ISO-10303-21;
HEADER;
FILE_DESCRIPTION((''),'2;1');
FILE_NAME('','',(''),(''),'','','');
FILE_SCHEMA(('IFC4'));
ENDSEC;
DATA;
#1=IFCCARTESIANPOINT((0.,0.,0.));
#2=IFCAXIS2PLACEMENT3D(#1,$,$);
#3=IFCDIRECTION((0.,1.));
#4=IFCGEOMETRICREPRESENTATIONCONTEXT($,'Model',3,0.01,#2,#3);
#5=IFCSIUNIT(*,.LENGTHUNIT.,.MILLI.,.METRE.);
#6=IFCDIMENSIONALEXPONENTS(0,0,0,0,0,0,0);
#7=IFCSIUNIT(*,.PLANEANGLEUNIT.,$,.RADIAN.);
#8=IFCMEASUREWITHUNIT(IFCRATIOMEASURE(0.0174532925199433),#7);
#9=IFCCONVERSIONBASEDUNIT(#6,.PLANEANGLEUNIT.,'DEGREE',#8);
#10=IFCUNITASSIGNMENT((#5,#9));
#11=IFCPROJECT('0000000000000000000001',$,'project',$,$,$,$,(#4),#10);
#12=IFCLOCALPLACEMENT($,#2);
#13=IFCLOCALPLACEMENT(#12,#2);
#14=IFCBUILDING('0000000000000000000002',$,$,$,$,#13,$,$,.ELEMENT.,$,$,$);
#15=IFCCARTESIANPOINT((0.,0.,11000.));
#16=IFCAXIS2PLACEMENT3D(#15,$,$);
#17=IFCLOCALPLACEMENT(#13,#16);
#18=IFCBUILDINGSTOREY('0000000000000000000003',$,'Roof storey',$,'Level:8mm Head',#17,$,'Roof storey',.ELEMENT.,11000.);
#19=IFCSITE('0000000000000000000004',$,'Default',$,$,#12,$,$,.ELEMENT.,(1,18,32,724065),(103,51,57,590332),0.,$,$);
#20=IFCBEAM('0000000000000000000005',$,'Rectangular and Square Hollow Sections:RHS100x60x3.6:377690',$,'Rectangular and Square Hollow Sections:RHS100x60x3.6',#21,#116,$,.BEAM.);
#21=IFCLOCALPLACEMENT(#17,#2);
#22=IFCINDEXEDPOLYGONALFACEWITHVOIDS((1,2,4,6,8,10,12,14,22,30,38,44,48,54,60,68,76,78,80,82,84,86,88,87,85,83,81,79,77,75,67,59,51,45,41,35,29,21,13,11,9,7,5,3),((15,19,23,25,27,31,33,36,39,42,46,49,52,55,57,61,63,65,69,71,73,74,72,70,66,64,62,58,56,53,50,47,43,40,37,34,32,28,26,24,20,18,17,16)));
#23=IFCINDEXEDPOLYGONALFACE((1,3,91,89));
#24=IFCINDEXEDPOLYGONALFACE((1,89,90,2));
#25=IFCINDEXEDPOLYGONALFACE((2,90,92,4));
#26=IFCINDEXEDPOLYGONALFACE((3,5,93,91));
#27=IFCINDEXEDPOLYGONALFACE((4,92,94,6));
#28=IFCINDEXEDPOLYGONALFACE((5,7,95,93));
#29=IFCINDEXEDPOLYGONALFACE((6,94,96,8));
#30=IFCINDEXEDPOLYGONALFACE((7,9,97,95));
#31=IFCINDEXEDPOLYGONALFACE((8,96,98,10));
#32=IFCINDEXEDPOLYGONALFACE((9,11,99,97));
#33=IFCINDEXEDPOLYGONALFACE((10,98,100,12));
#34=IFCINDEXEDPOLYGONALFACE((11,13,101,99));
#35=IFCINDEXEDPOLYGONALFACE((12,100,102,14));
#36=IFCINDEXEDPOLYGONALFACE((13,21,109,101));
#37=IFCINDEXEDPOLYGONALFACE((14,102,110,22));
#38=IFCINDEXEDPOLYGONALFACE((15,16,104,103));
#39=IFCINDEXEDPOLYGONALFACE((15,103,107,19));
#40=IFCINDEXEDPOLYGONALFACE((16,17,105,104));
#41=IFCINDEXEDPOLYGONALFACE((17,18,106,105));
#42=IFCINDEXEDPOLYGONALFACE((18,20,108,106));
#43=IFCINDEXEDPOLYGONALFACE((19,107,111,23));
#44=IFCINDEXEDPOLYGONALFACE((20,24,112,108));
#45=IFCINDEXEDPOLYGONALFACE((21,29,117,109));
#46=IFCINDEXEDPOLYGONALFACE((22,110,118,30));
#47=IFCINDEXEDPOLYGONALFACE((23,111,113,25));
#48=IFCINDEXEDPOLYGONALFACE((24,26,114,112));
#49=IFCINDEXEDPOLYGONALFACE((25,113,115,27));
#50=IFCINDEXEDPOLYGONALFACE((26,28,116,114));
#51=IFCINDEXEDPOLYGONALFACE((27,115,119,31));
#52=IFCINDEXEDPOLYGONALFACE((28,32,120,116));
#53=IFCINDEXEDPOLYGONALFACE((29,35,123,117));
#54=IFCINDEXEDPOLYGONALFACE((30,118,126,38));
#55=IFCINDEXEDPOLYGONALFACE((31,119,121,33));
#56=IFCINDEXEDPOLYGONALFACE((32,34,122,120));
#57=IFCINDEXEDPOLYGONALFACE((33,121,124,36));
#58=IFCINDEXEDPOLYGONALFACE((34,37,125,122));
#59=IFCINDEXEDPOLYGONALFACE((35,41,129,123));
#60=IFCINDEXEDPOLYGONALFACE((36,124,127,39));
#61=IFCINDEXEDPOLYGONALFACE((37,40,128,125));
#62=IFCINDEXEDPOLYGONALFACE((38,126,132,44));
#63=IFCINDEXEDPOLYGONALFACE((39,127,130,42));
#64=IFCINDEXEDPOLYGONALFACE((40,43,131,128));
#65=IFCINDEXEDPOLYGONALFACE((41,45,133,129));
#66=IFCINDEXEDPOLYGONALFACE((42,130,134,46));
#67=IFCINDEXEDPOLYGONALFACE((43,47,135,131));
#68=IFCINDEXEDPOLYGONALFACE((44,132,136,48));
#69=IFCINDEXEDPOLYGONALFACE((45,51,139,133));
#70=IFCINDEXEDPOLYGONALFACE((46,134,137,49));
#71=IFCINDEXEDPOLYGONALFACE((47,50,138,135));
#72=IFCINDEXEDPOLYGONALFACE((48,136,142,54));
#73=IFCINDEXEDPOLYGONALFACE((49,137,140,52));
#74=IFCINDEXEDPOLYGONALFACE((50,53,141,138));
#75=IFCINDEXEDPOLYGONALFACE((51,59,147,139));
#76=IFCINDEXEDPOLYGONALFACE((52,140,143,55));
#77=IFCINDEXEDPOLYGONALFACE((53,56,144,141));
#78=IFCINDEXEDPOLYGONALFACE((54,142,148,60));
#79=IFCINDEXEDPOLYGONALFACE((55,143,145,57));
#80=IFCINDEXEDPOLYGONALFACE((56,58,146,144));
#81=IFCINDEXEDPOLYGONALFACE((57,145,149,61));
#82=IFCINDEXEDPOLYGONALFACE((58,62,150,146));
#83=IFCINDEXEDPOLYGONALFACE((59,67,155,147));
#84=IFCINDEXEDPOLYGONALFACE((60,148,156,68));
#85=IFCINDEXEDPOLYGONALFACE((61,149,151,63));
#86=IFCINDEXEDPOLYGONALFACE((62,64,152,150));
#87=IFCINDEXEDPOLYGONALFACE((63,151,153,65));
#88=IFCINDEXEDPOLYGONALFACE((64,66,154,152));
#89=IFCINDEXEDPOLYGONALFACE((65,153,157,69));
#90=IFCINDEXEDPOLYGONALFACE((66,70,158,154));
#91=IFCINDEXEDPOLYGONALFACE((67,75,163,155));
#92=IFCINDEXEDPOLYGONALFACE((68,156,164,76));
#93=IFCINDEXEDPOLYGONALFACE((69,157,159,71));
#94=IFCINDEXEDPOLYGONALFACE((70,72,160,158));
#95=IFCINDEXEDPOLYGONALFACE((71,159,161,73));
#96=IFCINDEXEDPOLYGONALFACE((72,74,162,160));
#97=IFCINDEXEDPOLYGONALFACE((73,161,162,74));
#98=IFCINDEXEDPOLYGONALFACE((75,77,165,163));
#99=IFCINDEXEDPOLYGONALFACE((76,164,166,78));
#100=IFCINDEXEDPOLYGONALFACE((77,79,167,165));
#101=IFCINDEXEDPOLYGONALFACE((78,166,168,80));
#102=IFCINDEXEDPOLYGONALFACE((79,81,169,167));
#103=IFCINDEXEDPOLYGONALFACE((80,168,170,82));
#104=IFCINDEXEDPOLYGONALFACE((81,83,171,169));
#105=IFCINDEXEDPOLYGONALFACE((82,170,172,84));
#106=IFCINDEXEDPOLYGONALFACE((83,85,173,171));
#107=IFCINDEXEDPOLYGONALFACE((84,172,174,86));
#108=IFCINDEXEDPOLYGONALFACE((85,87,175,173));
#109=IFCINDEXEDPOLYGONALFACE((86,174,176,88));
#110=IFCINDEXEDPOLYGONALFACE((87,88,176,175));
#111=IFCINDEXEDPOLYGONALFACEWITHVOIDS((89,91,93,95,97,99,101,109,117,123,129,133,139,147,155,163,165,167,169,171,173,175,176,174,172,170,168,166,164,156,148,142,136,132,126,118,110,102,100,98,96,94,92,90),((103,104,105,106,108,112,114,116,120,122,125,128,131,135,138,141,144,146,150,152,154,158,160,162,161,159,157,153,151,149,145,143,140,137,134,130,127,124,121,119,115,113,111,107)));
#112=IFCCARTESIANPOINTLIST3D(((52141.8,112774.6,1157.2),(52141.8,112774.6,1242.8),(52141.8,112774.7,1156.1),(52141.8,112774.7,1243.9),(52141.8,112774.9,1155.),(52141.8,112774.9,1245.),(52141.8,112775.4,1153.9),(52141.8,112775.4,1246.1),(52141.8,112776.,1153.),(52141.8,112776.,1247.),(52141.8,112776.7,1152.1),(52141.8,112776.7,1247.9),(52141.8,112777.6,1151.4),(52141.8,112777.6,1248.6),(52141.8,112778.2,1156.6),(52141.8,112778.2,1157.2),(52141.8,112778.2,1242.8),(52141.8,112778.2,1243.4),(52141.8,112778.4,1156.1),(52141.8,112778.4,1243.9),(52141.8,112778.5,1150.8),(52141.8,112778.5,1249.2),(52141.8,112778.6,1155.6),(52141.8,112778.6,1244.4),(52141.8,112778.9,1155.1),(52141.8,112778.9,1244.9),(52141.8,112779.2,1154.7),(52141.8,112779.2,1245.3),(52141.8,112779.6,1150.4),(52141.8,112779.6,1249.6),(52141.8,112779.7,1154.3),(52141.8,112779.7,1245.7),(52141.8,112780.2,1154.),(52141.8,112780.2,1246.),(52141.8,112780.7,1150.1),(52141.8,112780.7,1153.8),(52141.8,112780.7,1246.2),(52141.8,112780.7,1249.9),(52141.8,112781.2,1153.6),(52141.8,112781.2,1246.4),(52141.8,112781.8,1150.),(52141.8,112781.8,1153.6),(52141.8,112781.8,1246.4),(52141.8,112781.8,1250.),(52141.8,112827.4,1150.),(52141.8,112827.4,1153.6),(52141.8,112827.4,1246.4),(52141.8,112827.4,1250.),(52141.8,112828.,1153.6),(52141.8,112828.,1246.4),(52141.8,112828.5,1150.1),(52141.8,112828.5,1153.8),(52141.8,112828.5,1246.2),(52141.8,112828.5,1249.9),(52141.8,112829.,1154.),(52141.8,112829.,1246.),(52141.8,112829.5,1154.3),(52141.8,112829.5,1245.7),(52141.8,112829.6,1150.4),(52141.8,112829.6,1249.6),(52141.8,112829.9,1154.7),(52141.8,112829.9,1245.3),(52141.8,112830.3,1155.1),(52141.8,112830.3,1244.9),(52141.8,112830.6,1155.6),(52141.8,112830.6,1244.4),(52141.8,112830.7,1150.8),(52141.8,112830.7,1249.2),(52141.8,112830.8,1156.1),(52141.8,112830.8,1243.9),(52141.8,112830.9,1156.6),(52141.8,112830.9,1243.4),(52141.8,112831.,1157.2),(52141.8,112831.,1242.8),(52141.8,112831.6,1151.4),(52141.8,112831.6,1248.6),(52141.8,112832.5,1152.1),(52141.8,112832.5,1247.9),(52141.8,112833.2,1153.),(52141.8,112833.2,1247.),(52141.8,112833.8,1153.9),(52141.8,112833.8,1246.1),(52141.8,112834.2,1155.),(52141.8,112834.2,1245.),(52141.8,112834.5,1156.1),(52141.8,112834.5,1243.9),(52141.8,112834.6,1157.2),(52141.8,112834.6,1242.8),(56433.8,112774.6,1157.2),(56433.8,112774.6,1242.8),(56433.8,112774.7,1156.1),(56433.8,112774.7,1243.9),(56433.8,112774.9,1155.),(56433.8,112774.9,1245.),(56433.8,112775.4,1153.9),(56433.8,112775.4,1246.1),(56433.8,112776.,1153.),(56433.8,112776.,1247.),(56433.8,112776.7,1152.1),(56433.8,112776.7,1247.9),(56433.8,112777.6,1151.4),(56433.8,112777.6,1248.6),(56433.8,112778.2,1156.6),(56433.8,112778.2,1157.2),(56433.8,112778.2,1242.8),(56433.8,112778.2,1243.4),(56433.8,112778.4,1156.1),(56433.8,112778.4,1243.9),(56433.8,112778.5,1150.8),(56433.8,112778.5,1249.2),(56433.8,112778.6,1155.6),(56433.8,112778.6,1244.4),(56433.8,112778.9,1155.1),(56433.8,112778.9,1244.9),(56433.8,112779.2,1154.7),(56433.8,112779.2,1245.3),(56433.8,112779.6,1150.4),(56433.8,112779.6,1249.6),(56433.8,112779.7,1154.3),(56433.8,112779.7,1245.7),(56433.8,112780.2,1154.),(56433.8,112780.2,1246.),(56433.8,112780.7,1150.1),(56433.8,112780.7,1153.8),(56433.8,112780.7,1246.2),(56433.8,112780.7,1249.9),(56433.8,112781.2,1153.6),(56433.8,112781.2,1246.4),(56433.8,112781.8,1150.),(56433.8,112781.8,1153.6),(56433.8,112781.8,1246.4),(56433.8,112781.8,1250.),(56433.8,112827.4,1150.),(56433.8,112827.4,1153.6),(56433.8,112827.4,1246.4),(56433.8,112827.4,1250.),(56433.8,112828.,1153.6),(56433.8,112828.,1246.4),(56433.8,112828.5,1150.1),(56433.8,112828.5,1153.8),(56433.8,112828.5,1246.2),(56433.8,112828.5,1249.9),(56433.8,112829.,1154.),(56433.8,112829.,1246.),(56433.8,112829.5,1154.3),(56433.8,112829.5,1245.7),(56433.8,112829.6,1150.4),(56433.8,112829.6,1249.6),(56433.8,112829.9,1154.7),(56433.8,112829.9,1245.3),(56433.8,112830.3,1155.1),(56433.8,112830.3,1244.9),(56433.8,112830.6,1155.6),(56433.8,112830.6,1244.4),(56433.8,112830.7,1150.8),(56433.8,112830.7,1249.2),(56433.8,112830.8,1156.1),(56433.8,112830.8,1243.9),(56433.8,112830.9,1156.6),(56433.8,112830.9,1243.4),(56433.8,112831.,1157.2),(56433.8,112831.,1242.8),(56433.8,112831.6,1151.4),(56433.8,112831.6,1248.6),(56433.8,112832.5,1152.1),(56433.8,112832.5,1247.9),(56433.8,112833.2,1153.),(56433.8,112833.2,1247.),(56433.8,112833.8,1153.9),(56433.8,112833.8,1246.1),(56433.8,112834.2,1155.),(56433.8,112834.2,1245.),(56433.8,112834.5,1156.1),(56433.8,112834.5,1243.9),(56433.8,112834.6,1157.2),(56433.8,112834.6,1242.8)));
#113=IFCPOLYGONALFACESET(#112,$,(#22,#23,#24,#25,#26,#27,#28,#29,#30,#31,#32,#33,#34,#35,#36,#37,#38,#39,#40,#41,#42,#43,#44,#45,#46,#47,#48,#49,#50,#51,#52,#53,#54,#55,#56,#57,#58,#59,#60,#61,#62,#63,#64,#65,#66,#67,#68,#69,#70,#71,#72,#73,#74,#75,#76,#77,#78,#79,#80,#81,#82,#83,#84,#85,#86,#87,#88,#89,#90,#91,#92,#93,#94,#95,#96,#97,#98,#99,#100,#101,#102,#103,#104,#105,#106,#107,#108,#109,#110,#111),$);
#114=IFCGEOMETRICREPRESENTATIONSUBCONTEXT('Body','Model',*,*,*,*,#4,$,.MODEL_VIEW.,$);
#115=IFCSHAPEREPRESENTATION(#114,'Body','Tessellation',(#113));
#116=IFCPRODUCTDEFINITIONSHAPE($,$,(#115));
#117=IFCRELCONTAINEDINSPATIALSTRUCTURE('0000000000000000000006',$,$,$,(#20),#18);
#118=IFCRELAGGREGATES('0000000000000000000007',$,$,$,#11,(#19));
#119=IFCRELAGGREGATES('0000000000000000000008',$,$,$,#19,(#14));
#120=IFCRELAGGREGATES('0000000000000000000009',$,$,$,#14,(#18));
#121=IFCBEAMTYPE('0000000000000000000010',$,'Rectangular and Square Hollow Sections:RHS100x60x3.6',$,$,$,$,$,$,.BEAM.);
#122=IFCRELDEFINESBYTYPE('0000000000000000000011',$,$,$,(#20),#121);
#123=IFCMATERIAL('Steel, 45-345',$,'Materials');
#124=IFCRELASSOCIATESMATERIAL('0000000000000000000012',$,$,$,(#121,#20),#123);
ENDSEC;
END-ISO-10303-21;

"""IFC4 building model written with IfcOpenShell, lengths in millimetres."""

from ifc_helpers import new_model, entity, si_unit, converted_unit, direction, frame, origin, place, context, subcontext, project, spatial, indexed_curve, outline, extrude, source, transform, mapped, material, type_object, type_shapes, element, save


model = new_model("IFC4")

# Units and contexts
model_context = context("Model", 3, precision=0.01, world=origin(), true_north=direction((0.0, 1.0)))
body_context = subcontext(model_context, "Body", "Model", "MODEL_VIEW")
ifc_project = project(units=[si_unit("LENGTHUNIT", "METRE", prefix="MILLI"), converted_unit("PLANEANGLEUNIT", "DEGREE", entity("IfcRatioMeasure", 0.0174532925199433), si_unit("PLANEANGLEUNIT", "RADIAN"), dimensions=[0, 0, 0, 0, 0, 0, 0])], contexts=[model_context])

# Site, building, storey
site_placement = place(None, origin())
site = spatial("IfcSite", under=ifc_project, at=site_placement, Name="Default", CompositionType="ELEMENT", RefLatitude=(1, 18, 32, 724065), RefLongitude=(103, 51, 57, 590332), RefElevation=0.0)
building_placement = place(site_placement, origin())
building = spatial("IfcBuilding", under=site, at=building_placement, CompositionType="ELEMENT")
storey_placement = place(building_placement, frame((0.0, 0.0, 11000.0)))
storey = spatial("IfcBuildingStorey", under=building, at=storey_placement, Name="Roof storey", ObjectType="Level:8mm Head", LongName="Roof storey", CompositionType="ELEMENT", Elevation=11000.0)

# Shared definitions
ifc_material = material(Name="Steel, 45-345", Category="Materials")

# Beam
beam_type_1 = type_object("IfcBeamType", Name="Rectangular and Square Hollow Sections:RHS100x60x3.6", PredefinedType="BEAM", material=ifc_material)
shared_shape_1 = source(origin(), body_context, "Body", "SweptSolid", [
    extrude(outline(indexed_curve([(-30.0, -42.8), (-29.9, -43.9), (-29.6, -45.0), (-29.2, -46.1), (-28.6, -47.0), (-27.9, -47.9), (-27.0, -48.6), (-26.1, -49.2), (-25.0, -49.6), (-23.9, -49.9), (-22.8, -50.0), (22.8, -50.0), (23.9, -49.9), (25.0, -49.6), (26.1, -49.2), (27.0, -48.6), (27.9, -47.9), (28.6, -47.0), (29.2, -46.1), (29.6, -45.0), (29.9, -43.9), (30.0, -42.8), (30.0, 42.8), (29.9, 43.9), (29.6, 45.0), (29.2, 46.1), (28.6, 47.0), (27.9, 47.9), (27.0, 48.6), (26.1, 49.2), (25.0, 49.6), (23.9, 49.9), (22.8, 50.0), (-22.8, 50.0), (-23.9, 49.9), (-25.0, 49.6), (-26.1, 49.2), (-27.0, 48.6), (-27.9, 47.9), (-28.6, 47.0), (-29.2, 46.1), (-29.6, 45.0), (-29.9, 43.9), (-30.0, 42.8), (-30.0, -42.8)], self_intersect=False), holes=[indexed_curve([(22.8, -46.4), (-22.8, -46.4), (-23.4, -46.4), (-23.9, -46.2), (-24.4, -46.0), (-24.9, -45.7), (-25.3, -45.3), (-25.7, -44.9), (-26.0, -44.4), (-26.2, -43.9), (-26.4, -43.4), (-26.4, -42.8), (-26.4, 42.8), (-26.4, 43.4), (-26.2, 43.9), (-26.0, 44.4), (-25.7, 44.9), (-25.3, 45.3), (-24.9, 45.7), (-24.4, 46.0), (-23.9, 46.2), (-23.4, 46.4), (-22.8, 46.4), (22.8, 46.4), (23.4, 46.4), (23.9, 46.2), (24.4, 46.0), (24.9, 45.7), (25.3, 45.3), (25.7, 44.9), (26.0, 44.4), (26.2, 43.9), (26.4, 43.4), (26.4, 42.8), (26.4, -42.8), (26.4, -43.4), (26.2, -43.9), (26.0, -44.4), (25.7, -44.9), (25.3, -45.3), (24.9, -45.7), (24.4, -46.0), (23.9, -46.2), (23.4, -46.4), (22.8, -46.4)], self_intersect=False)]), frame((-2152.5, 0.0, 0.0), z_axis=(1.0, 0.0, 0.0), x_axis=(0.0, -1.0, 0.0)), (0.0, 0.0, 1.0), 4292.0),
])
type_shapes(beam_type_1, [shared_shape_1])
for number, where, name in (
    (1, (54294.3, 112804.6, 1200.0), "Rectangular and Square Hollow Sections:RHS100x60x3.6:377690"),
):
    element("IfcBeam", number, at=place(storey_placement, frame(where)), inside=storey, type_object=beam_type_1, material=ifc_material, Name=name, ObjectType="Rectangular and Square Hollow Sections:RHS100x60x3.6", PredefinedType="BEAM", context=body_context, shape_type="MappedRepresentation", body=[
        mapped(shared_shape_1, transform((0.0, 0.0, 0.0), scale=1.0)),
    ])

save(model, "model.ifc")
